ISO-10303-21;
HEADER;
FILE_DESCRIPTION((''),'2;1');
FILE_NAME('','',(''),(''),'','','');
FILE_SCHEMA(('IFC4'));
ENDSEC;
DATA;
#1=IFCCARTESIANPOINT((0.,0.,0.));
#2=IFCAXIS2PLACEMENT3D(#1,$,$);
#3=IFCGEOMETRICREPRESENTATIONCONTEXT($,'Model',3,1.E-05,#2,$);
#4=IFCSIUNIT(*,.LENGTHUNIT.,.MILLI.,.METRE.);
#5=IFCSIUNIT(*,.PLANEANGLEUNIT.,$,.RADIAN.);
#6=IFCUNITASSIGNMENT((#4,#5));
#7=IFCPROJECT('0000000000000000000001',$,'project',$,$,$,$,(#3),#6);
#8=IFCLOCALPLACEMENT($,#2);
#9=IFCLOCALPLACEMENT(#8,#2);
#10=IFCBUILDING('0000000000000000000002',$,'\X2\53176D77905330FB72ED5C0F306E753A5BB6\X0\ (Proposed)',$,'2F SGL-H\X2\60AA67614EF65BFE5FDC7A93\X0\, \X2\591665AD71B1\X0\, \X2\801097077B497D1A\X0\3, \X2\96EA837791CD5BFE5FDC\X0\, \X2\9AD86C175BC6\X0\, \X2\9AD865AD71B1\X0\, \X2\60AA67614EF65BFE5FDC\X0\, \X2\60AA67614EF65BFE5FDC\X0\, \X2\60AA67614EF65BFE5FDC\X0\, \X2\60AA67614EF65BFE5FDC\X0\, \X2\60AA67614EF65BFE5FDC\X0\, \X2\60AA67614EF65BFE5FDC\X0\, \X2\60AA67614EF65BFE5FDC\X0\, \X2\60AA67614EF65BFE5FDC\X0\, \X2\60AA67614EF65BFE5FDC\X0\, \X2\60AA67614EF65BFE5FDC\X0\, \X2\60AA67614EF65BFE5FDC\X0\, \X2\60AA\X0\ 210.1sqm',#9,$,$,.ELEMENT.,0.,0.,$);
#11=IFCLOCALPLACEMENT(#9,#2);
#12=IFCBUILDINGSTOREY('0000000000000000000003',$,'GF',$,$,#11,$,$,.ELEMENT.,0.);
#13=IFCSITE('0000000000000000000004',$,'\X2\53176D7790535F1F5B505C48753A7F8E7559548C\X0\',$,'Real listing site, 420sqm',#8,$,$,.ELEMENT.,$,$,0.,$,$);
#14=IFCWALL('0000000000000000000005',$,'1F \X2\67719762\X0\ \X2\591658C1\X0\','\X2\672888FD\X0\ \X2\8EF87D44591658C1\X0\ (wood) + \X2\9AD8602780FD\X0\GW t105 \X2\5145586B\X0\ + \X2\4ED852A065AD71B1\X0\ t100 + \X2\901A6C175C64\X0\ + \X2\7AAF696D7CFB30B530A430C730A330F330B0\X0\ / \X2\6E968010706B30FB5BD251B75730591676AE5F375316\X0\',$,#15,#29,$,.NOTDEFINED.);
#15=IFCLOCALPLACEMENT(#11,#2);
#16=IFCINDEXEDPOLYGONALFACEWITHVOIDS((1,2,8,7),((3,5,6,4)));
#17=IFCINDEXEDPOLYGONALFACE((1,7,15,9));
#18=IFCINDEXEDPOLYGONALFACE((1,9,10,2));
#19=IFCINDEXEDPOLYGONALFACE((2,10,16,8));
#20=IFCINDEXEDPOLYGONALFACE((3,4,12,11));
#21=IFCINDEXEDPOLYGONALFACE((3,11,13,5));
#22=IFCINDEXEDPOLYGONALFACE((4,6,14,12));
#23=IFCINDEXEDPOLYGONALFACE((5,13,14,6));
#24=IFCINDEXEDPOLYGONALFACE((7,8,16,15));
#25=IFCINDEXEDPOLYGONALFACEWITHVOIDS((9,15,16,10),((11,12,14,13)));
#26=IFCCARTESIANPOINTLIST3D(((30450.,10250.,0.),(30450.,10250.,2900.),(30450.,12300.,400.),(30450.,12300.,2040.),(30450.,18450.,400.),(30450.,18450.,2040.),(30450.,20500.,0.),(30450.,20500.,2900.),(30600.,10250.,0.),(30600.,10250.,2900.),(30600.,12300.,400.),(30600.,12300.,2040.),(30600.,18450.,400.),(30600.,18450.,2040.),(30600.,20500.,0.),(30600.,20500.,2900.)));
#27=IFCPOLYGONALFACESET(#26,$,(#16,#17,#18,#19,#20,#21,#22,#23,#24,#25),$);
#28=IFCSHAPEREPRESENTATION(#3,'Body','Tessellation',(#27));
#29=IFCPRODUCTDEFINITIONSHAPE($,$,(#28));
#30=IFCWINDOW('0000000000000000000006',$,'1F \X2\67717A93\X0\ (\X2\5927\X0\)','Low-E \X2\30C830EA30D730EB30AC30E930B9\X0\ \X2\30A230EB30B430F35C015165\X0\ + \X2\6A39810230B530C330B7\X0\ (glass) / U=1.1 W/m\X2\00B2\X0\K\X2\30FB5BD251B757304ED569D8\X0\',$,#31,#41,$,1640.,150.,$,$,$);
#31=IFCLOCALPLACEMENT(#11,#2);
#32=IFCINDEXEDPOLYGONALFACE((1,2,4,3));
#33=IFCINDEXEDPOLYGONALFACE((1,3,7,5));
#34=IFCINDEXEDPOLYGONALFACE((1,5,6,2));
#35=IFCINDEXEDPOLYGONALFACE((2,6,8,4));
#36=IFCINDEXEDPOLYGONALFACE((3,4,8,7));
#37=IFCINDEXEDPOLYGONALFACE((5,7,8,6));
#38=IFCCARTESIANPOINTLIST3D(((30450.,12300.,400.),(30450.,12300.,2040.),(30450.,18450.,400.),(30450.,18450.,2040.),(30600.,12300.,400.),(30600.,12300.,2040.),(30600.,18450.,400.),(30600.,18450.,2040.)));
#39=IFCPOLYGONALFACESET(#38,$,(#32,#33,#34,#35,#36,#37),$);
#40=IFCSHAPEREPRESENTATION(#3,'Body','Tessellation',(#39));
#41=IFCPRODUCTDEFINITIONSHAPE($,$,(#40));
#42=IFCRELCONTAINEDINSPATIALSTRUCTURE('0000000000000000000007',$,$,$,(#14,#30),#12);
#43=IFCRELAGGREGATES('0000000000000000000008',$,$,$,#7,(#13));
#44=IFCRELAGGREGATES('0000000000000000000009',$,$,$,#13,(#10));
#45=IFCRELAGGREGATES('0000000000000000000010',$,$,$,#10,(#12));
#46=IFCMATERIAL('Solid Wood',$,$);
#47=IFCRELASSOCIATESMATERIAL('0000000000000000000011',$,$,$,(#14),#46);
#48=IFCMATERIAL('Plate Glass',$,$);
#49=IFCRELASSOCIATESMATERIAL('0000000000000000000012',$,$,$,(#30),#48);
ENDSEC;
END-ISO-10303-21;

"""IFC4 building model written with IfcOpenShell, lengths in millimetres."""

from ifc_helpers import new_model, si_unit, frame, frame_2d, origin, place, context, project, spatial, rectangle, extrude, material, element, fill, save


model = new_model("IFC4")

# Units and contexts
model_context = context("Model", 3, precision=1e-05, world=origin())
ifc_project = project(units=[si_unit("LENGTHUNIT", "METRE", prefix="MILLI"), si_unit("PLANEANGLEUNIT", "RADIAN")], contexts=[model_context])

# Site, building, storey
site_placement = place(None, origin())
site = spatial("IfcSite", under=ifc_project, at=site_placement, Name="北海道弟子屈町美留和", ObjectType="Real listing site, 420sqm", CompositionType="ELEMENT", RefElevation=0.0)
building_placement = place(site_placement, origin())
building = spatial("IfcBuilding", under=site, at=building_placement, Name="北海道・狭小の町家 (Proposed)", ObjectType="2F SGL-H悪条件対応窓, 外断熱, 耐震等級3, 雪荷重対応, 高気密, 高断熱, 悪条件対応, 悪条件対応, 悪条件対応, 悪条件対応, 悪条件対応, 悪条件対応, 悪条件対応, 悪条件対応, 悪条件対応, 悪条件対応, 悪条件対応, 悪 210.1sqm", CompositionType="ELEMENT", ElevationOfRefHeight=0.0, ElevationOfTerrain=0.0)
storey_placement = place(building_placement, origin())
storey = spatial("IfcBuildingStorey", under=building, at=storey_placement, Name="GF", CompositionType="ELEMENT", Elevation=0.0)

# Shared definitions
ifc_material_1 = material(Name="Solid Wood")

# Wall, opening, window
wall_1_placement = place(storey_placement, frame((15225.0, 5125.0, 0.0)))
wall_1 = element("IfcWall", 1, at=wall_1_placement, inside=storey, material=ifc_material_1, Name="1F 東面 外壁", Description="木製 軸組外壁 (wood) + 高性能GW t105 充填 + 付加断熱 t100 + 通気層 + 窯業系サイディング / 準耐火・寒冷地外皮強化", PredefinedType="NOTDEFINED", context=model_context, shape_type="SweptSolid", body=[
    extrude(rectangle(XDim=150.0, YDim=10250.0, at=frame_2d((75.0, 5125.0))), frame((15225.0, 5125.0, 0.0)), (0.0, 0.0, 1.0), 2900.0),
])
opening_1_placement = place(storey_placement, frame((15225.0, 6150.0, 200.0)))
opening_1 = element("IfcOpeningElement", 2, at=opening_1_placement, cuts=wall_1, PredefinedType="NOTDEFINED", context=model_context, shape_type="SweptSolid", body=[
    extrude(rectangle(XDim=150.0, YDim=6150.0, at=frame_2d((75.0, 3075.0))), frame((15225.0, 6150.0, 200.0)), (0.0, 0.0, 1.0), 1640.0),
])
ifc_material_2 = material(Name="Plate Glass")
window_1_placement = place(storey_placement, frame((15225.0, 6150.0, 200.0)))
window_1 = element("IfcWindow", 3, at=window_1_placement, inside=storey, material=ifc_material_2, Name="1F 東窓 (大)", Description="Low-E トリプルガラス アルゴン封入 + 樹脂サッシ (glass) / U=1.1 W/m²K・寒冷地仕様", OverallHeight=1640.0, OverallWidth=150.0, context=model_context, shape_type="SweptSolid", body=[
    extrude(rectangle(XDim=150.0, YDim=6150.0, at=frame_2d((75.0, 3075.0))), frame((15225.0, 6150.0, 200.0)), (0.0, 0.0, 1.0), 1640.0),
])
fill(opening_1, window_1)

save(model, "model.ifc")
